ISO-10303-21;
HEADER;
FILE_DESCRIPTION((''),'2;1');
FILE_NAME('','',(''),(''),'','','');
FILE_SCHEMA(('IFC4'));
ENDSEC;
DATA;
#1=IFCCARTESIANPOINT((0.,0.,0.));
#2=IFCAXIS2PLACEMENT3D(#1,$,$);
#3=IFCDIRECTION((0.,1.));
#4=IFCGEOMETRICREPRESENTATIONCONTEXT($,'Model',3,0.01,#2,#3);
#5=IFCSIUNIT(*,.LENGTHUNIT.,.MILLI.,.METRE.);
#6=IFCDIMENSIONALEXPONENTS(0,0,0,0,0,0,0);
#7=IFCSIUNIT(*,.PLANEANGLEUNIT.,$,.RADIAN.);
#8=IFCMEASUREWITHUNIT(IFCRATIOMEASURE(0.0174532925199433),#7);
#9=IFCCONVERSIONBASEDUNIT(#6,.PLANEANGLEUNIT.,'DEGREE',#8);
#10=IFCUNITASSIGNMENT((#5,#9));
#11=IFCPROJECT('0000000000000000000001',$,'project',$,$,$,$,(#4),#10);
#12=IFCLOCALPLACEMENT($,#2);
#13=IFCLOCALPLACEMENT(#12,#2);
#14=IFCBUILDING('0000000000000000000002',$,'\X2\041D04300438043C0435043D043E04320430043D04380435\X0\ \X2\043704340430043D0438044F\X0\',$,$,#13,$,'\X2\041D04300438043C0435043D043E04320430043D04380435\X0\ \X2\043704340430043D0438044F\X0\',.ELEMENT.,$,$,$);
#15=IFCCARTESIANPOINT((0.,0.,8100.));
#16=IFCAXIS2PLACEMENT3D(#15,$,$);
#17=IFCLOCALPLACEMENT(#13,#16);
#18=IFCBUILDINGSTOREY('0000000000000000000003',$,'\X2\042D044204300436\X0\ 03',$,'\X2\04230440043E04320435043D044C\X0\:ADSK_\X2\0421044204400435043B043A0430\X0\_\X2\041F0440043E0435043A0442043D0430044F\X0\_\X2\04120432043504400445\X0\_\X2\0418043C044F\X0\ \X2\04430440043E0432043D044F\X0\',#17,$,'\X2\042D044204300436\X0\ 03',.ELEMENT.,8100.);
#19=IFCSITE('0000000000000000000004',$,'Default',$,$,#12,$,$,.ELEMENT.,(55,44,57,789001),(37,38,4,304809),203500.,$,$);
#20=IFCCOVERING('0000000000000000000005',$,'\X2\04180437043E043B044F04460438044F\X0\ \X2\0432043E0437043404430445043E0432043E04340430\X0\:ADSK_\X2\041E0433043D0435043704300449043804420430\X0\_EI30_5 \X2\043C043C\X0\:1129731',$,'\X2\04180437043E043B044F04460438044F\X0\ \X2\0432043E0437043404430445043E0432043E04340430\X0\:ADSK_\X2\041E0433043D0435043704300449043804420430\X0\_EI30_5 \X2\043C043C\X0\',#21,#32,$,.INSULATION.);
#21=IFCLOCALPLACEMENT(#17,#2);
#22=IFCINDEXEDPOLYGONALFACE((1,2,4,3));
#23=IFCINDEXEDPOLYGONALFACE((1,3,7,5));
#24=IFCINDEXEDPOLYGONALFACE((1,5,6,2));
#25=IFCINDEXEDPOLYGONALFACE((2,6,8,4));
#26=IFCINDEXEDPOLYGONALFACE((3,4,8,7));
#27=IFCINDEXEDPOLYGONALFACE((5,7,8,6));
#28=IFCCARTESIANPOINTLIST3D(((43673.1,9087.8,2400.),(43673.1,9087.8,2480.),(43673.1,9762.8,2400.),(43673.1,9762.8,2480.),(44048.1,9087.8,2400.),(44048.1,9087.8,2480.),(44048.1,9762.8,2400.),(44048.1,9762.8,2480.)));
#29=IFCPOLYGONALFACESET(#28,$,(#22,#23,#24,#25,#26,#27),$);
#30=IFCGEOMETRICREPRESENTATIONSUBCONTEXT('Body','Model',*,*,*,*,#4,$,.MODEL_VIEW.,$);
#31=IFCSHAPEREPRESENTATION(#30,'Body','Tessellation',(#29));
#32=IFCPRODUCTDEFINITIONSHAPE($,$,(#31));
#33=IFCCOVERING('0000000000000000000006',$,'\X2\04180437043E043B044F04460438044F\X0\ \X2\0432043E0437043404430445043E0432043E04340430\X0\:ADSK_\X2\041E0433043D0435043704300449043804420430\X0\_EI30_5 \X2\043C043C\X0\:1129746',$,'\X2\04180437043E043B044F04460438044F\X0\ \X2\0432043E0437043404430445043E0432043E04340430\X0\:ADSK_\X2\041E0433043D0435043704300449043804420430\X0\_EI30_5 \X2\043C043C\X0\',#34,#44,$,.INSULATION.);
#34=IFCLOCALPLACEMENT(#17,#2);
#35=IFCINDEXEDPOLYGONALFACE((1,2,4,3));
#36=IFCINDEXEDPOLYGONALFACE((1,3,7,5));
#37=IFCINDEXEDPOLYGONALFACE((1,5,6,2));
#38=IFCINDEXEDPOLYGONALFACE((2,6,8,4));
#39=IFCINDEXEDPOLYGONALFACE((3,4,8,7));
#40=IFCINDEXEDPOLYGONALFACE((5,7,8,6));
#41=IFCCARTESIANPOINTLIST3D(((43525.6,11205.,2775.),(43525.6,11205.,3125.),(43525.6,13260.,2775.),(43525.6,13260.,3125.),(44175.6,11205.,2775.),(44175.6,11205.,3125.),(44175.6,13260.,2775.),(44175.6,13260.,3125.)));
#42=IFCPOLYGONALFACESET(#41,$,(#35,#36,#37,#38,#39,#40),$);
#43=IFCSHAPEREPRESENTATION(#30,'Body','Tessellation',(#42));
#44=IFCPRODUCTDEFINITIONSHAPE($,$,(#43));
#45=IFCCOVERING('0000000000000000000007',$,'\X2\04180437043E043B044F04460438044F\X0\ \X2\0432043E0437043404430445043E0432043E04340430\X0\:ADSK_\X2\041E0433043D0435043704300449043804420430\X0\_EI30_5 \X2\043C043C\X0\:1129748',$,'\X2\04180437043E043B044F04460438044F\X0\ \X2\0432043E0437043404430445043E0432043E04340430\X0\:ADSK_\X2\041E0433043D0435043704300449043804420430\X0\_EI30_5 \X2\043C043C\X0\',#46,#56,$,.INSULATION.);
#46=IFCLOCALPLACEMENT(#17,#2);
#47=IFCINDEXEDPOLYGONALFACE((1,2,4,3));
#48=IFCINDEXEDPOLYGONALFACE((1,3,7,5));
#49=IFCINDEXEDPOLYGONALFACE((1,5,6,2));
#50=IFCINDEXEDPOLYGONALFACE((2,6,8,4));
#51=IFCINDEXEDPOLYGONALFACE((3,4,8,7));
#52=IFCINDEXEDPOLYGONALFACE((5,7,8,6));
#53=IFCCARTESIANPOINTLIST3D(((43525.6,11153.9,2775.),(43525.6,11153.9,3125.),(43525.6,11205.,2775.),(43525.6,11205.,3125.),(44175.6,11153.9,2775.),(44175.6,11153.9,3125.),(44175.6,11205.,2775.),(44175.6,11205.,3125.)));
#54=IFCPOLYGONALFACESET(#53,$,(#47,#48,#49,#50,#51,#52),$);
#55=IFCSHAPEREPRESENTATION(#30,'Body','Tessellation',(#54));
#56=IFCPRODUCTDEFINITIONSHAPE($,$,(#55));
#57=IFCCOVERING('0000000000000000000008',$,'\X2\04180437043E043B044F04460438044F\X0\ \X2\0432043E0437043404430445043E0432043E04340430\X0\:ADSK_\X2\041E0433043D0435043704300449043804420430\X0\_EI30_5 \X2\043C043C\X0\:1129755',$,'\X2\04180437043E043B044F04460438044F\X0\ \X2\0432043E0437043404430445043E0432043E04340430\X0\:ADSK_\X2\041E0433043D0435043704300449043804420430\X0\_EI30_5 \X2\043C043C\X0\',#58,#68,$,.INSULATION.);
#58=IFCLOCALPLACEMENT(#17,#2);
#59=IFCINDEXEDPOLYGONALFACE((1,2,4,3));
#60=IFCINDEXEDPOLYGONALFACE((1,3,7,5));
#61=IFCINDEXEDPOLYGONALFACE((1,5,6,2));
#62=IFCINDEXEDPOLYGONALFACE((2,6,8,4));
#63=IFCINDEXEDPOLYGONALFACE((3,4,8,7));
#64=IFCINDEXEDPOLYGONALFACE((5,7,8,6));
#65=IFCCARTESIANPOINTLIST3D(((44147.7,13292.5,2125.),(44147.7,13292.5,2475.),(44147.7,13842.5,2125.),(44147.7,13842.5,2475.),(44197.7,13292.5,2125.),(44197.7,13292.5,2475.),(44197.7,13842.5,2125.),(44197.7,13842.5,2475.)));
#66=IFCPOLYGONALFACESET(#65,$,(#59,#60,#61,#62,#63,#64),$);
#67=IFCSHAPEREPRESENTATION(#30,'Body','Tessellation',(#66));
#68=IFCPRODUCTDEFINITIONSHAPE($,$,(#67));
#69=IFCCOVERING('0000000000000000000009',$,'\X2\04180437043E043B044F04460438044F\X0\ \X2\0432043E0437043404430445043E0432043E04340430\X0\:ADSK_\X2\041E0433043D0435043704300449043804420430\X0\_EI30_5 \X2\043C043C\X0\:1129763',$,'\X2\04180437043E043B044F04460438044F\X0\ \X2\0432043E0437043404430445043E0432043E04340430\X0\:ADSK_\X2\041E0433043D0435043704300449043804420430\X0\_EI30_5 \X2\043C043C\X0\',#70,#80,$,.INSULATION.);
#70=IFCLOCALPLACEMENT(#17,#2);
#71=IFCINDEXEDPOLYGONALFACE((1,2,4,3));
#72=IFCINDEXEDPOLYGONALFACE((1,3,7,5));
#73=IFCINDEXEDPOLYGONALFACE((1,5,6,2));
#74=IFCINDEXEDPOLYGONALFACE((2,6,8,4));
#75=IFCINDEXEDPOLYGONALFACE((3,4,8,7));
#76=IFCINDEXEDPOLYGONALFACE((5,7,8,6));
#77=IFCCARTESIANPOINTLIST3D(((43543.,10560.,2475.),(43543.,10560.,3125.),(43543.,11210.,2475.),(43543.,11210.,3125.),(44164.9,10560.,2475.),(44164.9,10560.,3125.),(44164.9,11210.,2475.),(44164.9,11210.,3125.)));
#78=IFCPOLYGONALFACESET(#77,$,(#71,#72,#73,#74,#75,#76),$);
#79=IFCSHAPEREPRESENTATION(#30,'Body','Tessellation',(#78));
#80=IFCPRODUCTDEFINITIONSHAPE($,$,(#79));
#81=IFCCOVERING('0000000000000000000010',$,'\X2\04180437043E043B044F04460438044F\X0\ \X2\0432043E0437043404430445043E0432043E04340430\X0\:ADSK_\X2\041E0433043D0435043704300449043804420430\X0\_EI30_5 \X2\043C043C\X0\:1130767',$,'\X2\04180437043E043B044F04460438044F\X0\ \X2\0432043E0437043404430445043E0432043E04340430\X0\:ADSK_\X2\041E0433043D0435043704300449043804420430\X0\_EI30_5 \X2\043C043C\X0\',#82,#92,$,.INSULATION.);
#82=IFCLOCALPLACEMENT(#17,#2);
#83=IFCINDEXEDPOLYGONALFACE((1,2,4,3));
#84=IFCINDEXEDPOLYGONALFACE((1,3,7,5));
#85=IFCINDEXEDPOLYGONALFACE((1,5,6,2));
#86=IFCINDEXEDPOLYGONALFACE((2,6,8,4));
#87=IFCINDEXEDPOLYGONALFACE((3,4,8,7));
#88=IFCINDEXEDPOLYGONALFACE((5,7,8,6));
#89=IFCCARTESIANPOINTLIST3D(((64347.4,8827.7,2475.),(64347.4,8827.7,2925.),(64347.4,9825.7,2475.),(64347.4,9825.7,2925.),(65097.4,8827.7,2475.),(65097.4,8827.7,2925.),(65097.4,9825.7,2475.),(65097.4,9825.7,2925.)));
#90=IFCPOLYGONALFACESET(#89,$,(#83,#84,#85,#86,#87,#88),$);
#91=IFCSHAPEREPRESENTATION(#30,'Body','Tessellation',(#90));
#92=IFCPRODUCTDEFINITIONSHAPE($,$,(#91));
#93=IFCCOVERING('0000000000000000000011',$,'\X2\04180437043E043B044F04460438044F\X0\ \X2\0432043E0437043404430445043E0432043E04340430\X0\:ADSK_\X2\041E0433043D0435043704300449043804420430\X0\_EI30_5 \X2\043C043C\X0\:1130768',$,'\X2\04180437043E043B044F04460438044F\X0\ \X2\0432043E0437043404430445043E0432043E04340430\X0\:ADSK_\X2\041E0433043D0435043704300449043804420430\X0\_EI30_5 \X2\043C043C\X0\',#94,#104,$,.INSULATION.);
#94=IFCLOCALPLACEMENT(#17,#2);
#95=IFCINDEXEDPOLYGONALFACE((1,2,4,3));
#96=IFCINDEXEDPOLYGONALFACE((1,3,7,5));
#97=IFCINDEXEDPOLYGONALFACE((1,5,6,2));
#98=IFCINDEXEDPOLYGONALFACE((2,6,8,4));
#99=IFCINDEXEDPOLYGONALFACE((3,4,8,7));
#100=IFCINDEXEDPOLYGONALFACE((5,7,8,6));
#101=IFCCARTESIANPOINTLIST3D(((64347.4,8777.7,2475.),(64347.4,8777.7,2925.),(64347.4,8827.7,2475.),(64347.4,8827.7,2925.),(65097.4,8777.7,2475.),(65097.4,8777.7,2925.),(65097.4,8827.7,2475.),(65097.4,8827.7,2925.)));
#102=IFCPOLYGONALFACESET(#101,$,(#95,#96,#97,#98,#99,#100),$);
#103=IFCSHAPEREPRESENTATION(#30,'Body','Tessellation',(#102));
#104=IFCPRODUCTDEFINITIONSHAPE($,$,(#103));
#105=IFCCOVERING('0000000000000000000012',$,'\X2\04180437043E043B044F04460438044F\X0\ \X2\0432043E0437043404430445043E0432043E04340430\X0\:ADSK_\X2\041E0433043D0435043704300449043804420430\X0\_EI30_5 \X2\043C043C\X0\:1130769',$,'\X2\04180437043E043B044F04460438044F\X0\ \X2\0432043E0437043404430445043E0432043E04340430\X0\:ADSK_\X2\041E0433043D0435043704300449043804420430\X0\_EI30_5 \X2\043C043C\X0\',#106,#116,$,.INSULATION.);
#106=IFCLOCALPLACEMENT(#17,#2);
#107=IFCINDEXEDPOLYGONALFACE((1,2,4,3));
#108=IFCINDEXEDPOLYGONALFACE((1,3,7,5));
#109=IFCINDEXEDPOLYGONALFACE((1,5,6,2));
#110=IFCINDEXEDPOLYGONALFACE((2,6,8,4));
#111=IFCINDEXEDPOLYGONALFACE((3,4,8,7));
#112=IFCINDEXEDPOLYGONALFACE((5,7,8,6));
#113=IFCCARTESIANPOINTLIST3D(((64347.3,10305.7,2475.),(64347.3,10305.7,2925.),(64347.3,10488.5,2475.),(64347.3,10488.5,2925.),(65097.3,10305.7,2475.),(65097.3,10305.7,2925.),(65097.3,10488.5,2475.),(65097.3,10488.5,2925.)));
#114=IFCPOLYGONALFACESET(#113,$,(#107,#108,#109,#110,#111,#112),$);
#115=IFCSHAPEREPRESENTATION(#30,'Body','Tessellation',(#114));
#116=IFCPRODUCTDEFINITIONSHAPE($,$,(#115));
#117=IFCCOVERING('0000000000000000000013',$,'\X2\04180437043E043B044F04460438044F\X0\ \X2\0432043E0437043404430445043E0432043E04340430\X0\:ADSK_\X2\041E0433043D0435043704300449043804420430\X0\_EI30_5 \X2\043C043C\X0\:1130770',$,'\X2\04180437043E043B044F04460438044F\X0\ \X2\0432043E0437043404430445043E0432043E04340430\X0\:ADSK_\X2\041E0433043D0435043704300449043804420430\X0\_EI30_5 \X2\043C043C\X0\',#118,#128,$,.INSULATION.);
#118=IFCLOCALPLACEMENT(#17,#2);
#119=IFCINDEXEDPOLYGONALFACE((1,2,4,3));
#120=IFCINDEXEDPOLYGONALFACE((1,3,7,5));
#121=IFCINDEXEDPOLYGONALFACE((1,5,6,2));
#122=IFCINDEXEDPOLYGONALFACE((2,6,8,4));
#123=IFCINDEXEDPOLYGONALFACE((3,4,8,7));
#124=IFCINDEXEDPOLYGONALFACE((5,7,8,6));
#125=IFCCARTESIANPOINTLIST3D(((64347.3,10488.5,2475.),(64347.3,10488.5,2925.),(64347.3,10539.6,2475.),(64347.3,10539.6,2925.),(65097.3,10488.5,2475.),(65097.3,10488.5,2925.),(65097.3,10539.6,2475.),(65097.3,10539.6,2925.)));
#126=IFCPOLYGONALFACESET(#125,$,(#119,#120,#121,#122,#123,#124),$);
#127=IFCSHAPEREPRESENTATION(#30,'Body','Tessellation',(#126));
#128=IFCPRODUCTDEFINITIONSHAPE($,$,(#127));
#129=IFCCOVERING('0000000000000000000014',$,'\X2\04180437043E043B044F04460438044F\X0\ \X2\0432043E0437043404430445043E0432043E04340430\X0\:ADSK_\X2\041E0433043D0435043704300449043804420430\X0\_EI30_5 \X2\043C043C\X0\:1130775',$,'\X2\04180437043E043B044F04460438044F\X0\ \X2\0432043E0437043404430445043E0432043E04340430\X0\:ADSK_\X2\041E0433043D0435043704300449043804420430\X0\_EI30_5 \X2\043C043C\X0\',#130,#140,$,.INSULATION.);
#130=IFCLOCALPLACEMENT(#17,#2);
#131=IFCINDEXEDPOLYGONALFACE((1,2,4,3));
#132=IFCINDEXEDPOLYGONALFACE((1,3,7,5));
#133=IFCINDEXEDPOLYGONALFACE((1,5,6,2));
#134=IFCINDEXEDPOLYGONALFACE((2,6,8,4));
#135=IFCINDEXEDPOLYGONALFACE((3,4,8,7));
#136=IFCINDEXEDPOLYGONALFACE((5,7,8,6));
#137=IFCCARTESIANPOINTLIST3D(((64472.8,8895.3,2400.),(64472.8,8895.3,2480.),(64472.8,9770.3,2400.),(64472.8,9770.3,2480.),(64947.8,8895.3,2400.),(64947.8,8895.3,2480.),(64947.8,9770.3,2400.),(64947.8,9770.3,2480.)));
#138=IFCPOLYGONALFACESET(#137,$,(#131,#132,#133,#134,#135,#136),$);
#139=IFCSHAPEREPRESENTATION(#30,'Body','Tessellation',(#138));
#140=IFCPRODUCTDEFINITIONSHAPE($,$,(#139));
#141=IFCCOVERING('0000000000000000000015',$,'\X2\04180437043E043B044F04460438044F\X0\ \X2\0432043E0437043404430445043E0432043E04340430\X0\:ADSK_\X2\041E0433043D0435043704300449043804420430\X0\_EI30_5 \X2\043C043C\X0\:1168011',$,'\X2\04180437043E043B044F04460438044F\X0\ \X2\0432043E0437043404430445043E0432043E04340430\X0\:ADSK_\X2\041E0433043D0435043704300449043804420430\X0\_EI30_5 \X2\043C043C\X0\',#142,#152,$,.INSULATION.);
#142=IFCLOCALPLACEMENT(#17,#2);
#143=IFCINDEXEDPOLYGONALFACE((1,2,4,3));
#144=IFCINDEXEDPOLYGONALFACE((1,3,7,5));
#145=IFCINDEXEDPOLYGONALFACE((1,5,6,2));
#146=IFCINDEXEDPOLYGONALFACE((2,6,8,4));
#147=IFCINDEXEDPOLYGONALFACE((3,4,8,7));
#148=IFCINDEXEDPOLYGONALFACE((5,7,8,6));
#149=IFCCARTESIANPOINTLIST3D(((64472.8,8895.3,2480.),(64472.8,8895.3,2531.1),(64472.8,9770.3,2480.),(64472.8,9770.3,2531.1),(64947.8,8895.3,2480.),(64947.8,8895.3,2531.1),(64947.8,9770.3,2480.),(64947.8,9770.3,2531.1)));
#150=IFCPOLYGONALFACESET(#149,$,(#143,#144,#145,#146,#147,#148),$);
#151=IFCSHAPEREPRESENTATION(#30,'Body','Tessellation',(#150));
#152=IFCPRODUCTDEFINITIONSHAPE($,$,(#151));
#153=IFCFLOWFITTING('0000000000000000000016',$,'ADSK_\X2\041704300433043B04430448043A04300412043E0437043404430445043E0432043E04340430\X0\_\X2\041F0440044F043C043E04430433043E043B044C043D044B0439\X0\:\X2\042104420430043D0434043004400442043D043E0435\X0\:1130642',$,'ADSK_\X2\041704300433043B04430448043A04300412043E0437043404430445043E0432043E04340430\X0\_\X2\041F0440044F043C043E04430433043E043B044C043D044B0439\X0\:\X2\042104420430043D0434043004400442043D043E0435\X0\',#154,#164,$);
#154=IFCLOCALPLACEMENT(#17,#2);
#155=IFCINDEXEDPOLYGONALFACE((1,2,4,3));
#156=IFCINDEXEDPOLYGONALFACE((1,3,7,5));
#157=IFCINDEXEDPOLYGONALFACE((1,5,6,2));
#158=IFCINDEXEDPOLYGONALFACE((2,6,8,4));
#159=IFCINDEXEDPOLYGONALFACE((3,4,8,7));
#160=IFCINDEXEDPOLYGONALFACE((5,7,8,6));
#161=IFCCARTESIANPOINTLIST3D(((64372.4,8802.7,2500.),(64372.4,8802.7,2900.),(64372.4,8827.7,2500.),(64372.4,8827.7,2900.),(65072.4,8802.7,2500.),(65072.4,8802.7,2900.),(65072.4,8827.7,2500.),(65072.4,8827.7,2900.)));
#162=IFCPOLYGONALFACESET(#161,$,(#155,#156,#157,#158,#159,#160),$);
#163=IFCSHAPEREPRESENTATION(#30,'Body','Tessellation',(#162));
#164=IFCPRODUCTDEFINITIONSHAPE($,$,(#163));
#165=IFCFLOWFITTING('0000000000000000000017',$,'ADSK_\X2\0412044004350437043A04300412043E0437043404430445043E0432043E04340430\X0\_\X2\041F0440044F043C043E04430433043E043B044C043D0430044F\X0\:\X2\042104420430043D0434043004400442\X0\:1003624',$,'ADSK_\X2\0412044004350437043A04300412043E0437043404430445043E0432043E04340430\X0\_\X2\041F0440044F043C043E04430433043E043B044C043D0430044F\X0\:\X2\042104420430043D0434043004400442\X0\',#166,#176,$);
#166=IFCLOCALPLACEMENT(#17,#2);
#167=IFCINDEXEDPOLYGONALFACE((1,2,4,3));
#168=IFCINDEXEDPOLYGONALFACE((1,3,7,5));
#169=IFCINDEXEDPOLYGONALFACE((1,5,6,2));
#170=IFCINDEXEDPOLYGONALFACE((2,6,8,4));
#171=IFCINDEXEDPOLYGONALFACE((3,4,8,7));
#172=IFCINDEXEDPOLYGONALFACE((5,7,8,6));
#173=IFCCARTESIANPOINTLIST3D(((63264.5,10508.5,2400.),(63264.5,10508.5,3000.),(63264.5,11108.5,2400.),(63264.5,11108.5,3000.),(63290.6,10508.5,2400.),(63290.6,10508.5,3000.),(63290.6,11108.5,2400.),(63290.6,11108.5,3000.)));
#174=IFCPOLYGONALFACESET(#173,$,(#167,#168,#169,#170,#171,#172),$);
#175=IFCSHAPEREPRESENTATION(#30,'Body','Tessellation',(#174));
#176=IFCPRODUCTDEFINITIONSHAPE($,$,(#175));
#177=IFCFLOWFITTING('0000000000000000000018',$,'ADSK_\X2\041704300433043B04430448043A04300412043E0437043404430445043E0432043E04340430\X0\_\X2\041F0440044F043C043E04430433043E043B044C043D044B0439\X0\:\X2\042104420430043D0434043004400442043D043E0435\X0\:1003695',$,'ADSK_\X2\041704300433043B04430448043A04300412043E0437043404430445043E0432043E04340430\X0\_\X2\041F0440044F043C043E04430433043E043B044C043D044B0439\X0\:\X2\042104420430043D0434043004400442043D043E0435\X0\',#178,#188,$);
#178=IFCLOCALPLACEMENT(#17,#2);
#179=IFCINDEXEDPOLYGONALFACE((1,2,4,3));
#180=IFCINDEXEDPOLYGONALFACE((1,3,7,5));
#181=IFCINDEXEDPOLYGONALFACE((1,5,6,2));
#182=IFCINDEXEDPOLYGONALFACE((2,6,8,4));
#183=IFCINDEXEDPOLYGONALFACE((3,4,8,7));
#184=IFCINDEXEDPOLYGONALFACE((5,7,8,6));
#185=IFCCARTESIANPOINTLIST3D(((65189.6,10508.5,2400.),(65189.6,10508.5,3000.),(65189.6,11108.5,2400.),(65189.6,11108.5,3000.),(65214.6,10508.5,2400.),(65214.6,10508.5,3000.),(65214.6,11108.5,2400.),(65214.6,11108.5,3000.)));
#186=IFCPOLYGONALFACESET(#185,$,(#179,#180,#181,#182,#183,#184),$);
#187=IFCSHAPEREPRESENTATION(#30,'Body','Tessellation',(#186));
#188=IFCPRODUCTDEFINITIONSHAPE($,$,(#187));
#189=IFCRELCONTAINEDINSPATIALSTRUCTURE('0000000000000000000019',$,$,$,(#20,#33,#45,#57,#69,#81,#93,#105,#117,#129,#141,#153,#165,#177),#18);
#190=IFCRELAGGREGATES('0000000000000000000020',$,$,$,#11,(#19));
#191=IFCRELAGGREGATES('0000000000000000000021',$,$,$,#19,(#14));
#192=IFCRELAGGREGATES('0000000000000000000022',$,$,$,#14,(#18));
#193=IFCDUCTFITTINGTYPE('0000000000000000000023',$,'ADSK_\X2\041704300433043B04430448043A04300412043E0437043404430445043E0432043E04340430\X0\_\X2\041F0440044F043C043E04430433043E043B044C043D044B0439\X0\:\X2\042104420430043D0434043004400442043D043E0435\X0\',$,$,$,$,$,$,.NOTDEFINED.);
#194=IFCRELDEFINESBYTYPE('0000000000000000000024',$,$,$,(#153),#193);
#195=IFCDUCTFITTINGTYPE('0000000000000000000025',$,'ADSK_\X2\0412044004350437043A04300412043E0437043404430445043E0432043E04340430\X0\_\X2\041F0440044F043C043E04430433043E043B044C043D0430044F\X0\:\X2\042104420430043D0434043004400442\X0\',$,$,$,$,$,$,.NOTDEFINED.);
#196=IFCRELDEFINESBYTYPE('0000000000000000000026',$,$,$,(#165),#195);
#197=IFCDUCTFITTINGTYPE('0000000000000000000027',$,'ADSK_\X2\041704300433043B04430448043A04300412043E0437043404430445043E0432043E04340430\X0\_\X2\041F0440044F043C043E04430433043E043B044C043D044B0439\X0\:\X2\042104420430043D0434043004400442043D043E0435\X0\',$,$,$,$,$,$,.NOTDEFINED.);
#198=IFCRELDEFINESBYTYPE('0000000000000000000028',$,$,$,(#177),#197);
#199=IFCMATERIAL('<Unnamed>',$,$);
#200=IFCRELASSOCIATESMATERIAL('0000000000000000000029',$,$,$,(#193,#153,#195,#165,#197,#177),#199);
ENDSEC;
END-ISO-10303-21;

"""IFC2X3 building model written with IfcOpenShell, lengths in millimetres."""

from ifc_helpers import new_model, entity, si_unit, converted_unit, direction, frame, origin, origin_2d_with_axis, place, context, subcontext, project, spatial, rectangle, extrude, source, transform, mapped, material, type_object, type_shapes, element, save


model = new_model("IFC2X3")

# Units and contexts
model_context = context("Model", 3, precision=0.01, world=origin(), true_north=direction((0.0, 1.0)))
body_context = subcontext(model_context, "Body", "Model", "MODEL_VIEW")
ifc_project = project(units=[si_unit("LENGTHUNIT", "METRE", prefix="MILLI"), converted_unit("PLANEANGLEUNIT", "DEGREE", entity("IfcRatioMeasure", 0.0174532925199433), si_unit("PLANEANGLEUNIT", "RADIAN"), dimensions=[0, 0, 0, 0, 0, 0, 0])], contexts=[model_context])

# Site, building, storey
site_placement = place(None, origin())
site = spatial("IfcSite", under=ifc_project, at=site_placement, Name="Default", CompositionType="ELEMENT", RefLatitude=(55, 44, 57, 789001), RefLongitude=(37, 38, 4, 304809), RefElevation=203500.0)
building_placement = place(site_placement, origin())
building = spatial("IfcBuilding", under=site, at=building_placement, Name="Наименование здания", LongName="Наименование здания", CompositionType="ELEMENT")
storey_placement = place(building_placement, frame((0.0, 0.0, 8100.0)))
storey = spatial("IfcBuildingStorey", under=building, at=storey_placement, Name="Этаж 03", ObjectType="Уровень:ADSK_Стрелка_Проектная_Вверх_Имя уровня", LongName="Этаж 03", CompositionType="ELEMENT", Elevation=8100.0)

# Coverings
covering_1_placement = place(storey_placement, frame((43673.1, 9087.8, 2400.0)))
element("IfcCovering", 1, at=covering_1_placement, inside=storey, Name="Изоляция воздуховода:ADSK_Огнезащита_EI30_5 мм:1129731", ObjectType="Изоляция воздуховода:ADSK_Огнезащита_EI30_5 мм", PredefinedType="INSULATION", context=body_context, shape_type="SweptSolid", body=[
    extrude(rectangle(XDim=375.0, YDim=675.0, at=origin_2d_with_axis()), frame((187.5, 337.5, 0.0)), (0.0, 0.0, 1.0), 80.0),
])
covering_2_placement = place(storey_placement, frame((43525.6, 11205.0, 2775.0)))
element("IfcCovering", 2, at=covering_2_placement, inside=storey, Name="Изоляция воздуховода:ADSK_Огнезащита_EI30_5 мм:1129746", ObjectType="Изоляция воздуховода:ADSK_Огнезащита_EI30_5 мм", PredefinedType="INSULATION", context=body_context, shape_type="SweptSolid", body=[
    extrude(rectangle(XDim=2055.0, YDim=650.0, at=origin_2d_with_axis()), frame((325.0, 1027.5, 0.0), z_axis=(0.0, 0.0, 1.0), x_axis=(0.0, 1.0, 0.0)), (0.0, 0.0, 1.0), 350.0),
])
covering_3_placement = place(storey_placement, frame((43525.6, 11153.9, 2775.0)))
element("IfcCovering", 3, at=covering_3_placement, inside=storey, Name="Изоляция воздуховода:ADSK_Огнезащита_EI30_5 мм:1129748", ObjectType="Изоляция воздуховода:ADSK_Огнезащита_EI30_5 мм", PredefinedType="INSULATION", context=body_context, shape_type="SweptSolid", body=[
    extrude(rectangle(XDim=51.1, YDim=650.0, at=origin_2d_with_axis()), frame((325.0, 25.6, 0.0), z_axis=(0.0, 0.0, 1.0), x_axis=(0.0, -1.0, 0.0)), (0.0, 0.0, 1.0), 350.0),
])
covering_4_placement = place(storey_placement, frame((44147.7, 13292.5, 2125.0)))
element("IfcCovering", 4, at=covering_4_placement, inside=storey, Name="Изоляция воздуховода:ADSK_Огнезащита_EI30_5 мм:1129755", ObjectType="Изоляция воздуховода:ADSK_Огнезащита_EI30_5 мм", PredefinedType="INSULATION", context=body_context, shape_type="SweptSolid", body=[
    extrude(rectangle(XDim=50.0, YDim=550.0, at=origin_2d_with_axis()), frame((25.0, 275.0, 0.0), z_axis=(0.0, 0.0, 1.0), x_axis=(-1.0, 0.0, 0.0)), (0.0, 0.0, 1.0), 350.0),
])
covering_5_placement = place(storey_placement, frame((43543.0, 10560.0, 2475.0)))
element("IfcCovering", 5, at=covering_5_placement, inside=storey, Name="Изоляция воздуховода:ADSK_Огнезащита_EI30_5 мм:1129763", ObjectType="Изоляция воздуховода:ADSK_Огнезащита_EI30_5 мм", PredefinedType="INSULATION", context=body_context, shape_type="SweptSolid", body=[
    extrude(rectangle(XDim=621.9, YDim=650.0, at=origin_2d_with_axis()), frame((310.9, 325.0, 0.0)), (0.0, 0.0, 1.0), 650.0),
])
covering_6_placement = place(storey_placement, frame((64347.3, 8827.7, 2475.0)))
element("IfcCovering", 6, at=covering_6_placement, inside=storey, Name="Изоляция воздуховода:ADSK_Огнезащита_EI30_5 мм:1130767", ObjectType="Изоляция воздуховода:ADSK_Огнезащита_EI30_5 мм", PredefinedType="INSULATION", context=body_context, shape_type="SweptSolid", body=[
    extrude(rectangle(XDim=998.0, YDim=750.0, at=origin_2d_with_axis()), frame((375.0, 499.0, 0.0), z_axis=(0.0, 0.0, 1.0), x_axis=(0.0, -1.0, 0.0)), (0.0, 0.0, 1.0), 450.0),
])
covering_7_placement = place(storey_placement, frame((64347.3, 8777.7, 2475.0)))
element("IfcCovering", 7, at=covering_7_placement, inside=storey, Name="Изоляция воздуховода:ADSK_Огнезащита_EI30_5 мм:1130768", ObjectType="Изоляция воздуховода:ADSK_Огнезащита_EI30_5 мм", PredefinedType="INSULATION", context=body_context, shape_type="SweptSolid", body=[
    extrude(rectangle(XDim=50.0, YDim=750.0, at=origin_2d_with_axis()), frame((375.0, 25.0, 0.0), z_axis=(0.0, 0.0, 1.0), x_axis=(0.0, 1.0, 0.0)), (0.0, 0.0, 1.0), 450.0),
])
covering_8_placement = place(storey_placement, frame((64347.3, 10305.7, 2475.0)))
element("IfcCovering", 8, at=covering_8_placement, inside=storey, Name="Изоляция воздуховода:ADSK_Огнезащита_EI30_5 мм:1130769", ObjectType="Изоляция воздуховода:ADSK_Огнезащита_EI30_5 мм", PredefinedType="INSULATION", context=body_context, shape_type="SweptSolid", body=[
    extrude(rectangle(XDim=182.8, YDim=750.0, at=origin_2d_with_axis()), frame((375.0, 91.4, 0.0), z_axis=(0.0, 0.0, 1.0), x_axis=(0.0, 1.0, 0.0)), (0.0, 0.0, 1.0), 450.0),
])
covering_9_placement = place(storey_placement, frame((64347.3, 10488.5, 2475.0)))
element("IfcCovering", 9, at=covering_9_placement, inside=storey, Name="Изоляция воздуховода:ADSK_Огнезащита_EI30_5 мм:1130770", ObjectType="Изоляция воздуховода:ADSK_Огнезащита_EI30_5 мм", PredefinedType="INSULATION", context=body_context, shape_type="SweptSolid", body=[
    extrude(rectangle(XDim=750.0, YDim=51.1, at=origin_2d_with_axis()), frame((375.0, 25.6, 0.0)), (0.0, 0.0, 1.0), 450.0),
])
covering_10_placement = place(storey_placement, frame((64472.8, 8895.3, 2400.0)))
element("IfcCovering", 10, at=covering_10_placement, inside=storey, Name="Изоляция воздуховода:ADSK_Огнезащита_EI30_5 мм:1130775", ObjectType="Изоляция воздуховода:ADSK_Огнезащита_EI30_5 мм", PredefinedType="INSULATION", context=body_context, shape_type="SweptSolid", body=[
    extrude(rectangle(XDim=875.0, YDim=475.0, at=origin_2d_with_axis()), frame((237.5, 437.5, 0.0), z_axis=(0.0, 0.0, 1.0), x_axis=(0.0, -1.0, 0.0)), (0.0, 0.0, 1.0), 80.0),
])
covering_11_placement = place(storey_placement, frame((64472.8, 8895.3, 2480.0)))
element("IfcCovering", 11, at=covering_11_placement, inside=storey, Name="Изоляция воздуховода:ADSK_Огнезащита_EI30_5 мм:1168011", ObjectType="Изоляция воздуховода:ADSK_Огнезащита_EI30_5 мм", PredefinedType="INSULATION", context=body_context, shape_type="SweptSolid", body=[
    extrude(rectangle(XDim=875.0, YDim=475.0, at=origin_2d_with_axis()), frame((237.5, 437.5, 0.0), z_axis=(0.0, 0.0, 1.0), x_axis=(0.0, -1.0, 0.0)), (0.0, 0.0, 1.0), 51.1),
])

# Flow fittings
ifc_material_1 = material(Name="<Unnamed>")
duct_fitting_type_1 = type_object("IfcDuctFittingType", Name="ADSK_ЗаглушкаВоздуховода_Прямоугольный:Стандартное", PredefinedType="NOTDEFINED", material=ifc_material_1)
shared_shape_1 = source(origin(), body_context, "Body", "SweptSolid", [
    extrude(rectangle(XDim=25.0, YDim=700.0, at=origin_2d_with_axis()), frame((12.5, 0.0, -200.0)), (0.0, 0.0, 1.0), 400.0),
])
type_shapes(duct_fitting_type_1, [shared_shape_1])
flow_fitting_1_placement = place(storey_placement, frame((64722.3, 8827.7, 2700.0), z_axis=(0.0, 0.0, 1.0), x_axis=(0.0, -1.0, 0.0)))
element("IfcFlowFitting", 12, at=flow_fitting_1_placement, inside=storey, type_object=duct_fitting_type_1, material=ifc_material_1, Name="ADSK_ЗаглушкаВоздуховода_Прямоугольный:Стандартное:1130642", ObjectType="ADSK_ЗаглушкаВоздуховода_Прямоугольный:Стандартное", context=body_context, shape_type="MappedRepresentation", body=[
    mapped(shared_shape_1, transform((0.0, 0.0, 0.0), scale=1.0)),
])
duct_fitting_type_2 = type_object("IfcDuctFittingType", Name="ADSK_ВрезкаВоздуховода_Прямоугольная:Стандарт", PredefinedType="NOTDEFINED", material=ifc_material_1)
shared_shape_2 = source(origin(), body_context, "Body", "SweptSolid", [
    extrude(rectangle(XDim=26.1, YDim=600.0, at=origin_2d_with_axis()), frame((7.0, 0.0, -300.0)), (0.0, 0.0, 1.0), 600.0),
])
type_shapes(duct_fitting_type_2, [shared_shape_2])
flow_fitting_2_placement = place(storey_placement, frame((63270.6, 10808.5, 2700.0), z_axis=(0.0, -1.0, 0.0), x_axis=(1.0, 0.0, 0.0)))
element("IfcFlowFitting", 13, at=flow_fitting_2_placement, inside=storey, type_object=duct_fitting_type_2, material=ifc_material_1, Name="ADSK_ВрезкаВоздуховода_Прямоугольная:Стандарт:1003624", ObjectType="ADSK_ВрезкаВоздуховода_Прямоугольная:Стандарт", context=body_context, shape_type="MappedRepresentation", body=[
    mapped(shared_shape_2, transform((0.0, 0.0, 0.0), scale=1.0)),
])
duct_fitting_type_3 = type_object("IfcDuctFittingType", Name="ADSK_ЗаглушкаВоздуховода_Прямоугольный:Стандартное", PredefinedType="NOTDEFINED", material=ifc_material_1)
shared_shape_3 = source(origin(), body_context, "Body", "SweptSolid", [
    extrude(rectangle(XDim=25.0, YDim=600.0, at=origin_2d_with_axis()), frame((12.5, 0.0, -300.0)), (0.0, 0.0, 1.0), 600.0),
])
type_shapes(duct_fitting_type_3, [shared_shape_3])
flow_fitting_3_placement = place(storey_placement, frame((65189.6, 10808.5, 2700.0)))
element("IfcFlowFitting", 14, at=flow_fitting_3_placement, inside=storey, type_object=duct_fitting_type_3, material=ifc_material_1, Name="ADSK_ЗаглушкаВоздуховода_Прямоугольный:Стандартное:1003695", ObjectType="ADSK_ЗаглушкаВоздуховода_Прямоугольный:Стандартное", context=body_context, shape_type="MappedRepresentation", body=[
    mapped(shared_shape_3, transform((0.0, 0.0, 0.0), scale=1.0)),
])

save(model, "model.ifc")
